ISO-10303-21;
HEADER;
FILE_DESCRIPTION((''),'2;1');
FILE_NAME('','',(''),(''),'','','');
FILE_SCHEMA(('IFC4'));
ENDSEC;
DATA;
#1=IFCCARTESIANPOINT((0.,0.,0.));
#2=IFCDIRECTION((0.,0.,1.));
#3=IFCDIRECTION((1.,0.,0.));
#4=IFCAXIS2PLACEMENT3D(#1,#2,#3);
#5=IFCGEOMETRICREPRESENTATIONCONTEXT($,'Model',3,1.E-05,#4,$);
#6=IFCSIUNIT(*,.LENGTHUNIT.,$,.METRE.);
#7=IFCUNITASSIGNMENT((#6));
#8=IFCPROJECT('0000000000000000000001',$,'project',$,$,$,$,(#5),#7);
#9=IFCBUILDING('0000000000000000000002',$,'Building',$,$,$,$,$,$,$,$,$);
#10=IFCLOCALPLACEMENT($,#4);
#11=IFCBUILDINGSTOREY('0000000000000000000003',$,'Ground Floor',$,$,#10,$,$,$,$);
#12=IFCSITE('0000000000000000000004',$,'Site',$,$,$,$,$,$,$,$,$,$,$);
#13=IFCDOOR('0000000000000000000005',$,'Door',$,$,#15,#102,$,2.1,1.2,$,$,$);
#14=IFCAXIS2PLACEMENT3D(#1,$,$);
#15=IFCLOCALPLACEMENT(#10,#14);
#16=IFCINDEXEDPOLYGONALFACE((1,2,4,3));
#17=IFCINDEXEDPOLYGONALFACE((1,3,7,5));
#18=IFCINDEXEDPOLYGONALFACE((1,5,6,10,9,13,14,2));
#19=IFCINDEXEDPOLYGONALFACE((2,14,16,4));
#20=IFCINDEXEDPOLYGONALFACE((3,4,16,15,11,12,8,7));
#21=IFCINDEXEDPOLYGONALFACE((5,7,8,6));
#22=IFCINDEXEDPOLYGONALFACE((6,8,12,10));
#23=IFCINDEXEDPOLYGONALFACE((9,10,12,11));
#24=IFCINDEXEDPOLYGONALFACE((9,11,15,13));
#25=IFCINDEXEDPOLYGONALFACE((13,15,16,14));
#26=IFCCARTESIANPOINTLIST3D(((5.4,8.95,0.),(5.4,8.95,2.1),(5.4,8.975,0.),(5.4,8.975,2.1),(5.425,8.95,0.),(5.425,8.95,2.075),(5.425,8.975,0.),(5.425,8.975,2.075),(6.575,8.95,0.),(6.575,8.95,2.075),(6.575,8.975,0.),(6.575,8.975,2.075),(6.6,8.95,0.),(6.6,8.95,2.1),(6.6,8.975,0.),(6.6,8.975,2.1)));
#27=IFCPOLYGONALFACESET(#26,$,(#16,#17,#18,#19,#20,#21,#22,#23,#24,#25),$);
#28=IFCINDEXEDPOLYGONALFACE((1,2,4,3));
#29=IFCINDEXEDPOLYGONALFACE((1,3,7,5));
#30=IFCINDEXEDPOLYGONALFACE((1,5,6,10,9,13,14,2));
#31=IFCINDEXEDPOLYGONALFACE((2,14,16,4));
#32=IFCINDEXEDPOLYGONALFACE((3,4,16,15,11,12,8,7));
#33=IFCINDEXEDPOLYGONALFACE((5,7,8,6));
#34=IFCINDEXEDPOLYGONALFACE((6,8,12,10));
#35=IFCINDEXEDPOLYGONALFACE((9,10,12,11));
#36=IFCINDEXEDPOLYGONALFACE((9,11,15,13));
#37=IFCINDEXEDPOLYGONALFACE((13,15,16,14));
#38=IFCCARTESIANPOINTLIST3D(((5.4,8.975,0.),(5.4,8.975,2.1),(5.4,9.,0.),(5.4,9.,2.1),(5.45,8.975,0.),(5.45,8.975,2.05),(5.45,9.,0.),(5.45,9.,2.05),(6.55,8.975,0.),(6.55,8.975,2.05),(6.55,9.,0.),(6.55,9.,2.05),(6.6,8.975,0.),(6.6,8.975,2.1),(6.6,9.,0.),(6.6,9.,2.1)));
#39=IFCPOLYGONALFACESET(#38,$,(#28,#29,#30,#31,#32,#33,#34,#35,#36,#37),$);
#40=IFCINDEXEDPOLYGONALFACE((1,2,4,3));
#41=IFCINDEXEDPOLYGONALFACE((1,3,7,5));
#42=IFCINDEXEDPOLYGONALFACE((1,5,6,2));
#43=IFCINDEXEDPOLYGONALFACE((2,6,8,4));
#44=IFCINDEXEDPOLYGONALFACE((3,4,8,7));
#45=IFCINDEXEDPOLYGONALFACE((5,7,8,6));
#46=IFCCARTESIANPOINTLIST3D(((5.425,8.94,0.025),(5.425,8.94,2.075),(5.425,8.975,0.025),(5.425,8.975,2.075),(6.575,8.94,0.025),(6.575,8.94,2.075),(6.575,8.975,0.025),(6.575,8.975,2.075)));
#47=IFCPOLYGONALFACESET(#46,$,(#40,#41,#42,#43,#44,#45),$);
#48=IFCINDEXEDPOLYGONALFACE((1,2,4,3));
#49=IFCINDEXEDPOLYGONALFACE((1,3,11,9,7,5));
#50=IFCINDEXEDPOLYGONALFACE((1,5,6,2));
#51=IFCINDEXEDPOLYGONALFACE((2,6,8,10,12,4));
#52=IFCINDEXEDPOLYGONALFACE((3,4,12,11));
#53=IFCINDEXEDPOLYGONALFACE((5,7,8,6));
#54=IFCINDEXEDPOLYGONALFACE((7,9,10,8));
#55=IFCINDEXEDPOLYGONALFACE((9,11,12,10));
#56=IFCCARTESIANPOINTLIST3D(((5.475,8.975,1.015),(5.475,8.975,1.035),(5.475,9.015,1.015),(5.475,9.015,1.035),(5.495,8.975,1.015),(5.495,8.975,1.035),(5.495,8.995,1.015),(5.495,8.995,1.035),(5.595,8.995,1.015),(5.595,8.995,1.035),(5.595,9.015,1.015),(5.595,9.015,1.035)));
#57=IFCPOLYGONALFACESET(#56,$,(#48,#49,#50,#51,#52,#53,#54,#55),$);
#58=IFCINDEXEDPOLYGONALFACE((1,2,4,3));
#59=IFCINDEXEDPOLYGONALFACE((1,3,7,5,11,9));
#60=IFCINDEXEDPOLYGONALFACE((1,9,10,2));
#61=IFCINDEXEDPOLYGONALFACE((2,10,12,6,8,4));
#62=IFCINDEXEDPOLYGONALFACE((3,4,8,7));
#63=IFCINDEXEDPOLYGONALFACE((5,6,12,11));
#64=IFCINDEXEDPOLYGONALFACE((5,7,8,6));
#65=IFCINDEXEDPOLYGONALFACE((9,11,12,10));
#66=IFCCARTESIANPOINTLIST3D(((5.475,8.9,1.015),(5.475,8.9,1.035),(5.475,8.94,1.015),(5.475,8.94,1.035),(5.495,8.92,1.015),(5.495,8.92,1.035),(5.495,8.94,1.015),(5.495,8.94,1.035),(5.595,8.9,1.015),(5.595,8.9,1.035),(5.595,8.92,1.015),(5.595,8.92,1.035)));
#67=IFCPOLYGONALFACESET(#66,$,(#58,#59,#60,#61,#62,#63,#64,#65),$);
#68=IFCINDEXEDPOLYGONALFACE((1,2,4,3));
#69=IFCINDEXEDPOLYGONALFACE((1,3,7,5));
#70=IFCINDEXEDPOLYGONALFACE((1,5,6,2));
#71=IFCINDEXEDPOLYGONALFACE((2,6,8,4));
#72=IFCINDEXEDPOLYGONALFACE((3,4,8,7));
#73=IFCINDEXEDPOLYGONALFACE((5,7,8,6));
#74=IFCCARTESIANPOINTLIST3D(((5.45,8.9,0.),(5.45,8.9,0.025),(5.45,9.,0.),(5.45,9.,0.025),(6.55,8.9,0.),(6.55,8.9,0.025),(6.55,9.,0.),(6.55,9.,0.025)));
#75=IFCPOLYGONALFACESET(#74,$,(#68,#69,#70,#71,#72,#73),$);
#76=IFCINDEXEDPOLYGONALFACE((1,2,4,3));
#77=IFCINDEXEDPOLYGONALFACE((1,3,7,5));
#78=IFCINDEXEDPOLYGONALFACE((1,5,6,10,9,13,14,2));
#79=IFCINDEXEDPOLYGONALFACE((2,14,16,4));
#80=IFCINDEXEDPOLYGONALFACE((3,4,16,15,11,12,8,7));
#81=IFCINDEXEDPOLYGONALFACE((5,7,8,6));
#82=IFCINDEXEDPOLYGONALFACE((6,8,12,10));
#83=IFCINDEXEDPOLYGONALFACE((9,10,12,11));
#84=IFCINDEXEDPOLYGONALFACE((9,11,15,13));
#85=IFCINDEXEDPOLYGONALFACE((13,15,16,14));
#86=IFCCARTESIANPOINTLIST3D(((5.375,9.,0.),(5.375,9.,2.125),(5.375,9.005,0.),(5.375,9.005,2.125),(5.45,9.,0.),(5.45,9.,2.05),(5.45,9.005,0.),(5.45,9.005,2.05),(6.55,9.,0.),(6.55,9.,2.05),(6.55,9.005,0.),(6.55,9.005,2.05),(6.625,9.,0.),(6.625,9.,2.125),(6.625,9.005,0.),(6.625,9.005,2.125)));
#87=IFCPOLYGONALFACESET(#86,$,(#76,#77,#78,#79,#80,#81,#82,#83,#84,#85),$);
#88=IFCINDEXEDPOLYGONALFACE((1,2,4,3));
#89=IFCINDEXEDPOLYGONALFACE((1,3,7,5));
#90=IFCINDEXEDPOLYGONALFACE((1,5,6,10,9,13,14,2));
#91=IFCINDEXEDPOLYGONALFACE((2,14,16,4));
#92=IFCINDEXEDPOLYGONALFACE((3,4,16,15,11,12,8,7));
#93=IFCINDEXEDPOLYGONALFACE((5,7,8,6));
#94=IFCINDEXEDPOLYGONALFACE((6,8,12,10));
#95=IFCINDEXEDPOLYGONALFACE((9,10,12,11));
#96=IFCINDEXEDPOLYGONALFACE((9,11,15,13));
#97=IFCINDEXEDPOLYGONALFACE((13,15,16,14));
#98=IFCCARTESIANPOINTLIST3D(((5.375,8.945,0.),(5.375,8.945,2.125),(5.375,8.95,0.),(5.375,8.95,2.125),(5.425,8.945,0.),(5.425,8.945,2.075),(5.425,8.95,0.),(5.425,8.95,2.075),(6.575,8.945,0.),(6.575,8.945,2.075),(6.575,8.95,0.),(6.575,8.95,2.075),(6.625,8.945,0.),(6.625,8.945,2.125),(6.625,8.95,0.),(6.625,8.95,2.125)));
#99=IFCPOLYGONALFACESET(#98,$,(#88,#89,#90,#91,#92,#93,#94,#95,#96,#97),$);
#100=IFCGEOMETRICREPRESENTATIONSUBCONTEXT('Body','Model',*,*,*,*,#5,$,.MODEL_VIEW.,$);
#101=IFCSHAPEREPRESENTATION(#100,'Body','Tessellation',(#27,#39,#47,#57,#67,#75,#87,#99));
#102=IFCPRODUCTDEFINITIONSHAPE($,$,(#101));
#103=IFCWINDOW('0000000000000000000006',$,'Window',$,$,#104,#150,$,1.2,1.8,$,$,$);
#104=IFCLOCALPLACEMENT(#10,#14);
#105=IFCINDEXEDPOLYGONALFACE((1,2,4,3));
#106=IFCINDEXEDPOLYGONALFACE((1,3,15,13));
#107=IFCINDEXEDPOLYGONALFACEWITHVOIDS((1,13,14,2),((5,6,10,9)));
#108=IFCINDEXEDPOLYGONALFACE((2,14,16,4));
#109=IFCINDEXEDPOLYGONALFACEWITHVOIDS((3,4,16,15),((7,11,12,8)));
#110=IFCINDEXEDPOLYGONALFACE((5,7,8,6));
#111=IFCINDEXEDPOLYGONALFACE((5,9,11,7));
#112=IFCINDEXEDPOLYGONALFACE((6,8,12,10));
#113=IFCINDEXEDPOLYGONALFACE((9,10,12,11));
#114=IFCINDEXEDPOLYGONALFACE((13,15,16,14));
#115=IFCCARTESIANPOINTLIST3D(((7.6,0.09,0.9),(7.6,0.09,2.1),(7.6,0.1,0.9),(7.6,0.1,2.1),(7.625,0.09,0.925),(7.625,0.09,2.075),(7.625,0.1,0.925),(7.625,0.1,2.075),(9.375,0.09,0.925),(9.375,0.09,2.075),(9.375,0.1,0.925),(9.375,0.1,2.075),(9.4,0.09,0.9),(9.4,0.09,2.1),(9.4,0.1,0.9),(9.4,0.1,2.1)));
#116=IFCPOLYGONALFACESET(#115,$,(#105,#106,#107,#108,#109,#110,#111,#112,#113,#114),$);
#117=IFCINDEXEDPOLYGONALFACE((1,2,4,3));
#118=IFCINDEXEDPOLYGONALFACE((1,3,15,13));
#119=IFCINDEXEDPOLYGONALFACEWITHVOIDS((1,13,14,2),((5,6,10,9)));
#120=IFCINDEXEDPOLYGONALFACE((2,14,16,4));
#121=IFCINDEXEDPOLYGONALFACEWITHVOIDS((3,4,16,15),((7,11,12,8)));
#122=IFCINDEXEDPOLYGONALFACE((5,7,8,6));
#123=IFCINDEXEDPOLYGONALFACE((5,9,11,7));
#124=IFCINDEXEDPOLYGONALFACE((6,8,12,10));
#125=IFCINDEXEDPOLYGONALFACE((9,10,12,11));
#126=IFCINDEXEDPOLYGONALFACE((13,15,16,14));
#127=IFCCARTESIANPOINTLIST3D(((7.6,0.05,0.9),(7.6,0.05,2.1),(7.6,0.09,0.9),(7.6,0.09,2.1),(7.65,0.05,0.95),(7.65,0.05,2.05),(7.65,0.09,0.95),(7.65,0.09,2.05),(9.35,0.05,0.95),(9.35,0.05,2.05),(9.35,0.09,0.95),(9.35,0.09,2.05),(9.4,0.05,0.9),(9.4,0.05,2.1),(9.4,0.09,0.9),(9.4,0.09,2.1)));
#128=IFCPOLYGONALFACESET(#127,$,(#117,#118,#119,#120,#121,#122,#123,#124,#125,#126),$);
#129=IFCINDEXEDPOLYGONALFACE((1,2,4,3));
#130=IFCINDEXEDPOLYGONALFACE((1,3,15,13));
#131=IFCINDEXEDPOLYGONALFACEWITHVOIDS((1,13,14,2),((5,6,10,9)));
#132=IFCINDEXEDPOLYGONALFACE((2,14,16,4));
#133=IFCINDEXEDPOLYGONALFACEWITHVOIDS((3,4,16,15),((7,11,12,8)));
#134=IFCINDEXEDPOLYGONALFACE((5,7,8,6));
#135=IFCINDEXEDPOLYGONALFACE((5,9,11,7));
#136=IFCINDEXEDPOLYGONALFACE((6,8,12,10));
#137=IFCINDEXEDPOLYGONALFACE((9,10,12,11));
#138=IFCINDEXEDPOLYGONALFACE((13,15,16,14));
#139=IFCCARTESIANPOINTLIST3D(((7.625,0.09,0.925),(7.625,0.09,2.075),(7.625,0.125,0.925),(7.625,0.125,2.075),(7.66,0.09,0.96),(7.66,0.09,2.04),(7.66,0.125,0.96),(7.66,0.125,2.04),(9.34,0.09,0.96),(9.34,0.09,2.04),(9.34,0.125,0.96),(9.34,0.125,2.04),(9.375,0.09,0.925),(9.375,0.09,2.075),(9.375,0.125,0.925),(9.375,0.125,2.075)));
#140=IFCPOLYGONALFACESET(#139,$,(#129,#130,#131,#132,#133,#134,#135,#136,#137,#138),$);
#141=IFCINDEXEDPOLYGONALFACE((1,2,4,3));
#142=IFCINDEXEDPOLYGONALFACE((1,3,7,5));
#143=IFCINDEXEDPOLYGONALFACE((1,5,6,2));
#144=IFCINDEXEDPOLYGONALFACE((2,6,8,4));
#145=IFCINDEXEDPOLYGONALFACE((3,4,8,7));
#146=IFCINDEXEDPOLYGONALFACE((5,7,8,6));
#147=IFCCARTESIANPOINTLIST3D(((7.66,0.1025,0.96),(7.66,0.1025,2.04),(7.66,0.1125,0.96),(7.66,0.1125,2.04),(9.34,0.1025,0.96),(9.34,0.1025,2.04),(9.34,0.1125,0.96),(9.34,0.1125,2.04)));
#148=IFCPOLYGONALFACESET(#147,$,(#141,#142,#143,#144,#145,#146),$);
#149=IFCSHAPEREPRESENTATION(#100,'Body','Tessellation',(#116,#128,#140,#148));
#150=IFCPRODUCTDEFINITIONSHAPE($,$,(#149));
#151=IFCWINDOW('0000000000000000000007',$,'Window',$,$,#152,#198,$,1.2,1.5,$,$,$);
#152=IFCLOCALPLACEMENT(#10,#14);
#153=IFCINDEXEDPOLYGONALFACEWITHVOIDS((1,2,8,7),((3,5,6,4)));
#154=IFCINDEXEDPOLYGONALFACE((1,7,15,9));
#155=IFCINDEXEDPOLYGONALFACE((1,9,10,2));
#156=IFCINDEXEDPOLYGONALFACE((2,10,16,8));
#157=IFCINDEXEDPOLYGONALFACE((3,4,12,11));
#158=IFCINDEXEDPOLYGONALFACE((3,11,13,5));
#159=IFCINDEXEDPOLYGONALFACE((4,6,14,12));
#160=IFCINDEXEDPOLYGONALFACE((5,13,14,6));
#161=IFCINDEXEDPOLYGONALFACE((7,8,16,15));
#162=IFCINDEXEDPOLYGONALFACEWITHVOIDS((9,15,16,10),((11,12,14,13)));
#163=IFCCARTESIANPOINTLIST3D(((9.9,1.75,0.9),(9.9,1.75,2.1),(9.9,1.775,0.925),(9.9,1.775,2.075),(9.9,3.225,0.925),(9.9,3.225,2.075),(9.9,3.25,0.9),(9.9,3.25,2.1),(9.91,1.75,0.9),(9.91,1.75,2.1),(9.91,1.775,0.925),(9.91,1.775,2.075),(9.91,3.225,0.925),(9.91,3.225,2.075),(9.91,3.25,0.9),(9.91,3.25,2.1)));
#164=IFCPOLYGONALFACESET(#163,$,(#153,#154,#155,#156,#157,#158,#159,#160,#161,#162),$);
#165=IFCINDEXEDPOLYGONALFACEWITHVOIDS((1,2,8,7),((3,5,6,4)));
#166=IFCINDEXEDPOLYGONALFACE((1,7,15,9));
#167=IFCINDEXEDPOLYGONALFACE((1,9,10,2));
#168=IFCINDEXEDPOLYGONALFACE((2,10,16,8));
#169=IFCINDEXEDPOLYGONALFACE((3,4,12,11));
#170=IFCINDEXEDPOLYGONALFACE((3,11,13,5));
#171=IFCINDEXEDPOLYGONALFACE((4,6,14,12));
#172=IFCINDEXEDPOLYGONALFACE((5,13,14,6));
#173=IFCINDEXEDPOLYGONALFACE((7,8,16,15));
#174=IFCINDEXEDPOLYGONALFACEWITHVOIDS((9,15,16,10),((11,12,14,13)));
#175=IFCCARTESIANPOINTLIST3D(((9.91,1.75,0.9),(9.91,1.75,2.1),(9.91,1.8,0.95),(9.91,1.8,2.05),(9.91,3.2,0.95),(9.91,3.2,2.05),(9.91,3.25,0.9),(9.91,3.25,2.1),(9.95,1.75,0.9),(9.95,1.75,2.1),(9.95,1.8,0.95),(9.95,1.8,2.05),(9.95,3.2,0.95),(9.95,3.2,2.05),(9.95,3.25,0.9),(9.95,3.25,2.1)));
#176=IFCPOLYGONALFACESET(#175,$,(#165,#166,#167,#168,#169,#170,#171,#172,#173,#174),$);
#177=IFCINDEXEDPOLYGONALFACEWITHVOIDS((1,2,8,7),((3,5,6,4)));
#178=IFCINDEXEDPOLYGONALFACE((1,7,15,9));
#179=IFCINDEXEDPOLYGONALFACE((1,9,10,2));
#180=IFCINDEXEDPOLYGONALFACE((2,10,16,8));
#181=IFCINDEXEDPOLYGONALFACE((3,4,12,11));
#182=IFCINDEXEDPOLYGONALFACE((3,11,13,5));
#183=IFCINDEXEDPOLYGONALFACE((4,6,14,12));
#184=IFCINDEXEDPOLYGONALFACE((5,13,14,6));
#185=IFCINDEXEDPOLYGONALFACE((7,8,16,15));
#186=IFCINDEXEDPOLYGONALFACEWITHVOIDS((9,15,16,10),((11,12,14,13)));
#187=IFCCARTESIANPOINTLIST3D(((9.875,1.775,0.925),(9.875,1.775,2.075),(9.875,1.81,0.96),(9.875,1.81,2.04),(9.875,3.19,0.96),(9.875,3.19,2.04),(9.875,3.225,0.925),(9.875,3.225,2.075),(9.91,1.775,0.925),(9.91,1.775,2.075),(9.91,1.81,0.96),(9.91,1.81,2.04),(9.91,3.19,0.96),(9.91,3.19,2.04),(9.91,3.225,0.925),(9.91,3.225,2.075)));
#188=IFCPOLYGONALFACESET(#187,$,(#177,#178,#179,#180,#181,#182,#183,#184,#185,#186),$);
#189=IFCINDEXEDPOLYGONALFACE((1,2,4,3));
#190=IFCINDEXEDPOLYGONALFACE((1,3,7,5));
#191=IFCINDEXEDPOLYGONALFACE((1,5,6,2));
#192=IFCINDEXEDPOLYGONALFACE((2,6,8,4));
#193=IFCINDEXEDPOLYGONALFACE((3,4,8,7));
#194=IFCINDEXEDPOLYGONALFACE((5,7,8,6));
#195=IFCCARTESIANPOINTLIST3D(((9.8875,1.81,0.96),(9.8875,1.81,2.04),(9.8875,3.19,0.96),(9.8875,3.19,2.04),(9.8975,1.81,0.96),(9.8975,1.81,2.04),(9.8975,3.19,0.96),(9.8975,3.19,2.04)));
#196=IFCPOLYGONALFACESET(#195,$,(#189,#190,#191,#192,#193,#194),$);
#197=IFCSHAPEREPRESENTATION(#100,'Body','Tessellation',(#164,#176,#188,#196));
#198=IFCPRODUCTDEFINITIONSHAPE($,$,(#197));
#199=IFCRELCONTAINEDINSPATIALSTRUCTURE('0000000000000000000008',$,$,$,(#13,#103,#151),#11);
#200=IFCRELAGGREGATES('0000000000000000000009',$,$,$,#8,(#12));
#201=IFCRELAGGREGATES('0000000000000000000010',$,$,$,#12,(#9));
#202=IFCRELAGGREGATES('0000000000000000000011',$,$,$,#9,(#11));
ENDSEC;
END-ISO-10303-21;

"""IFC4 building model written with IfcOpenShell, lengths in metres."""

from ifc_helpers import new_model, si_unit, frame, origin_with_axes, place, context, subcontext, project, spatial, line, indexed_curve, outline, extrude, element, save


model = new_model("IFC4")

# Units and contexts
model_context = context("Model", 3, precision=1e-05, world=origin_with_axes())
body_context = subcontext(model_context, "Body", "Model", "MODEL_VIEW")
ifc_project = project(units=[si_unit("LENGTHUNIT", "METRE")], contexts=[model_context])

# Site, building, storey
site = spatial("IfcSite", under=ifc_project, Name="Site")
building = spatial("IfcBuilding", under=site, Name="Building")
storey_placement = place(None, origin_with_axes())
storey = spatial("IfcBuildingStorey", under=building, at=storey_placement, Name="Ground Floor")

# Door
door_1_placement = place(storey_placement, frame((6.6, 9.0, 0.0), z_axis=(0.0, 0.0, 1.0), x_axis=(-1.0, 0.0, 0.0)))
element("IfcDoor", 1, at=door_1_placement, inside=storey, Name="Door", OverallHeight=2.1, OverallWidth=1.2, context=body_context, shape_type="SweptSolid", body=[
    extrude(outline(indexed_curve([(0.0, 0.0), (0.0, 2.1), (1.2, 2.1), (1.2, 0.0), (1.175, 0.0), (1.175, 2.075), (0.025, 2.075), (0.025, 0.0)], segments=[line(1, 2, 3, 4, 5, 6, 7, 8, 1)])), frame((0.0, 0.025, 0.0), z_axis=(0.0, -1.0, 0.0), x_axis=(1.0, 0.0, 0.0)), (0.0, 0.0, -1.0), 0.025),
    extrude(outline(indexed_curve([(0.0, 0.0), (0.0, 2.1), (1.2, 2.1), (1.2, 0.0), (1.15, 0.0), (1.15, 2.05), (0.05, 2.05), (0.05, 0.0)], segments=[line(1, 2, 3, 4, 5, 6, 7, 8, 1)])), frame((0.0, 0.0, 0.0), z_axis=(0.0, -1.0, 0.0), x_axis=(1.0, 0.0, 0.0)), (0.0, 0.0, -1.0), 0.025),
    extrude(outline(indexed_curve([(0.0, 0.0), (1.15, 0.0), (1.15, 0.035), (0.0, 0.035)], segments=[line(1, 2, 3, 4, 1)])), frame((0.025, 0.025, 0.025), z_axis=(0.0, 0.0, 1.0), x_axis=(1.0, 0.0, 0.0)), (0.0, 0.0, 1.0), 2.05),
    extrude(outline(indexed_curve([(0.0, 0.0), (0.0, -0.04), (-0.12, -0.04), (-0.12, -0.02), (-0.02, -0.02), (-0.02, 0.0)], segments=[line(1, 2, 3, 4, 5, 6, 1)])), frame((1.125, 0.025, 1.015), z_axis=(0.0, 0.0, 1.0), x_axis=(1.0, 0.0, 0.0)), (0.0, 0.0, 1.0), 0.02),
    extrude(outline(indexed_curve([(0.0, 0.0), (0.0, 0.04), (-0.12, 0.04), (-0.12, 0.02), (-0.02, 0.02), (-0.02, 0.0)], segments=[line(1, 2, 3, 4, 5, 6, 1)])), frame((1.125, 0.06, 1.015), z_axis=(0.0, 0.0, 1.0), x_axis=(1.0, 0.0, 0.0)), (0.0, 0.0, 1.0), 0.02),
    extrude(outline(indexed_curve([(0.0, 0.0), (1.1, 0.0), (1.1, 0.1), (0.0, 0.1)], segments=[line(1, 2, 3, 4, 1)])), frame((0.05, 0.0, 0.0), z_axis=(0.0, 0.0, 1.0), x_axis=(1.0, 0.0, 0.0)), (0.0, 0.0, 1.0), 0.025),
    extrude(outline(indexed_curve([(0.0, 0.0), (0.0, 2.125), (1.25, 2.125), (1.25, 0.0), (1.175, 0.0), (1.175, 2.05), (0.075, 2.05), (0.075, 0.0)], segments=[line(1, 2, 3, 4, 5, 6, 7, 8, 1)])), frame((-0.025, -0.005, 0.0), z_axis=(0.0, -1.0, 0.0), x_axis=(1.0, 0.0, 0.0)), (0.0, 0.0, -1.0), 0.005),
    extrude(outline(indexed_curve([(0.0, 0.0), (0.0, 2.125), (1.25, 2.125), (1.25, 0.0), (1.2, 0.0), (1.2, 2.075), (0.05, 2.075), (0.05, 0.0)], segments=[line(1, 2, 3, 4, 5, 6, 7, 8, 1)])), frame((-0.025, 0.05, 0.0), z_axis=(0.0, -1.0, 0.0), x_axis=(1.0, 0.0, 0.0)), (0.0, 0.0, -1.0), 0.005),
])

# Windows
window_1_placement = place(storey_placement, frame((7.6, 0.0, 0.9), z_axis=(0.0, 0.0, 1.0), x_axis=(1.0, 0.0, 0.0)))
element("IfcWindow", 2, at=window_1_placement, inside=storey, Name="Window", OverallHeight=1.2, OverallWidth=1.8, context=body_context, shape_type="SweptSolid", body=[
    extrude(outline(indexed_curve([(0.0, 0.0), (1.8, 0.0), (1.8, 1.2), (0.0, 1.2)], segments=[line(1, 2, 3, 4, 1)]), holes=[indexed_curve([(0.025, 0.025), (1.775, 0.025), (1.775, 1.175), (0.025, 1.175)], segments=[line(1, 2, 3, 4, 1)])]), frame((0.0, 0.09, 0.0), z_axis=(0.0, -1.0, 0.0), x_axis=(1.0, 0.0, 0.0)), (0.0, 0.0, -1.0), 0.01),
    extrude(outline(indexed_curve([(0.0, 0.0), (1.8, 0.0), (1.8, 1.2), (0.0, 1.2)], segments=[line(1, 2, 3, 4, 1)]), holes=[indexed_curve([(0.05, 0.05), (1.75, 0.05), (1.75, 1.15), (0.05, 1.15)], segments=[line(1, 2, 3, 4, 1)])]), frame((0.0, 0.05, 0.0), z_axis=(0.0, -1.0, 0.0), x_axis=(1.0, 0.0, 0.0)), (0.0, 0.0, -1.0), 0.04),
    extrude(outline(indexed_curve([(0.0, 0.0), (1.75, 0.0), (1.75, 1.15), (0.0, 1.15)], segments=[line(1, 2, 3, 4, 1)]), holes=[indexed_curve([(0.035, 0.035), (1.715, 0.035), (1.715, 1.115), (0.035, 1.115)], segments=[line(1, 2, 3, 4, 1)])]), frame((0.025, 0.09, 0.025), z_axis=(0.0, -1.0, 0.0), x_axis=(1.0, 0.0, 0.0)), (0.0, 0.0, -1.0), 0.035),
    extrude(outline(indexed_curve([(0.035, 0.035), (1.715, 0.035), (1.715, 1.115), (0.035, 1.115)], segments=[line(1, 2, 3, 4, 1)])), frame((0.025, 0.1025, 0.025), z_axis=(0.0, -1.0, 0.0), x_axis=(1.0, 0.0, 0.0)), (0.0, 0.0, -1.0), 0.01),
])
window_2_placement = place(storey_placement, frame((10.0, 1.75, 0.9), z_axis=(0.0, 0.0, 1.0), x_axis=(0.0, 1.0, 0.0)))
element("IfcWindow", 3, at=window_2_placement, inside=storey, Name="Window", OverallHeight=1.2, OverallWidth=1.5, context=body_context, shape_type="SweptSolid", body=[
    extrude(outline(indexed_curve([(0.0, 0.0), (1.5, 0.0), (1.5, 1.2), (0.0, 1.2)], segments=[line(1, 2, 3, 4, 1)]), holes=[indexed_curve([(0.025, 0.025), (1.475, 0.025), (1.475, 1.175), (0.025, 1.175)], segments=[line(1, 2, 3, 4, 1)])]), frame((0.0, 0.09, 0.0), z_axis=(0.0, -1.0, 0.0), x_axis=(1.0, 0.0, 0.0)), (0.0, 0.0, -1.0), 0.01),
    extrude(outline(indexed_curve([(0.0, 0.0), (1.5, 0.0), (1.5, 1.2), (0.0, 1.2)], segments=[line(1, 2, 3, 4, 1)]), holes=[indexed_curve([(0.05, 0.05), (1.45, 0.05), (1.45, 1.15), (0.05, 1.15)], segments=[line(1, 2, 3, 4, 1)])]), frame((0.0, 0.05, 0.0), z_axis=(0.0, -1.0, 0.0), x_axis=(1.0, 0.0, 0.0)), (0.0, 0.0, -1.0), 0.04),
    extrude(outline(indexed_curve([(0.0, 0.0), (1.45, 0.0), (1.45, 1.15), (0.0, 1.15)], segments=[line(1, 2, 3, 4, 1)]), holes=[indexed_curve([(0.035, 0.035), (1.415, 0.035), (1.415, 1.115), (0.035, 1.115)], segments=[line(1, 2, 3, 4, 1)])]), frame((0.025, 0.09, 0.025), z_axis=(0.0, -1.0, 0.0), x_axis=(1.0, 0.0, 0.0)), (0.0, 0.0, -1.0), 0.035),
    extrude(outline(indexed_curve([(0.035, 0.035), (1.415, 0.035), (1.415, 1.115), (0.035, 1.115)], segments=[line(1, 2, 3, 4, 1)])), frame((0.025, 0.1025, 0.025), z_axis=(0.0, -1.0, 0.0), x_axis=(1.0, 0.0, 0.0)), (0.0, 0.0, -1.0), 0.01),
])

save(model, "model.ifc")
